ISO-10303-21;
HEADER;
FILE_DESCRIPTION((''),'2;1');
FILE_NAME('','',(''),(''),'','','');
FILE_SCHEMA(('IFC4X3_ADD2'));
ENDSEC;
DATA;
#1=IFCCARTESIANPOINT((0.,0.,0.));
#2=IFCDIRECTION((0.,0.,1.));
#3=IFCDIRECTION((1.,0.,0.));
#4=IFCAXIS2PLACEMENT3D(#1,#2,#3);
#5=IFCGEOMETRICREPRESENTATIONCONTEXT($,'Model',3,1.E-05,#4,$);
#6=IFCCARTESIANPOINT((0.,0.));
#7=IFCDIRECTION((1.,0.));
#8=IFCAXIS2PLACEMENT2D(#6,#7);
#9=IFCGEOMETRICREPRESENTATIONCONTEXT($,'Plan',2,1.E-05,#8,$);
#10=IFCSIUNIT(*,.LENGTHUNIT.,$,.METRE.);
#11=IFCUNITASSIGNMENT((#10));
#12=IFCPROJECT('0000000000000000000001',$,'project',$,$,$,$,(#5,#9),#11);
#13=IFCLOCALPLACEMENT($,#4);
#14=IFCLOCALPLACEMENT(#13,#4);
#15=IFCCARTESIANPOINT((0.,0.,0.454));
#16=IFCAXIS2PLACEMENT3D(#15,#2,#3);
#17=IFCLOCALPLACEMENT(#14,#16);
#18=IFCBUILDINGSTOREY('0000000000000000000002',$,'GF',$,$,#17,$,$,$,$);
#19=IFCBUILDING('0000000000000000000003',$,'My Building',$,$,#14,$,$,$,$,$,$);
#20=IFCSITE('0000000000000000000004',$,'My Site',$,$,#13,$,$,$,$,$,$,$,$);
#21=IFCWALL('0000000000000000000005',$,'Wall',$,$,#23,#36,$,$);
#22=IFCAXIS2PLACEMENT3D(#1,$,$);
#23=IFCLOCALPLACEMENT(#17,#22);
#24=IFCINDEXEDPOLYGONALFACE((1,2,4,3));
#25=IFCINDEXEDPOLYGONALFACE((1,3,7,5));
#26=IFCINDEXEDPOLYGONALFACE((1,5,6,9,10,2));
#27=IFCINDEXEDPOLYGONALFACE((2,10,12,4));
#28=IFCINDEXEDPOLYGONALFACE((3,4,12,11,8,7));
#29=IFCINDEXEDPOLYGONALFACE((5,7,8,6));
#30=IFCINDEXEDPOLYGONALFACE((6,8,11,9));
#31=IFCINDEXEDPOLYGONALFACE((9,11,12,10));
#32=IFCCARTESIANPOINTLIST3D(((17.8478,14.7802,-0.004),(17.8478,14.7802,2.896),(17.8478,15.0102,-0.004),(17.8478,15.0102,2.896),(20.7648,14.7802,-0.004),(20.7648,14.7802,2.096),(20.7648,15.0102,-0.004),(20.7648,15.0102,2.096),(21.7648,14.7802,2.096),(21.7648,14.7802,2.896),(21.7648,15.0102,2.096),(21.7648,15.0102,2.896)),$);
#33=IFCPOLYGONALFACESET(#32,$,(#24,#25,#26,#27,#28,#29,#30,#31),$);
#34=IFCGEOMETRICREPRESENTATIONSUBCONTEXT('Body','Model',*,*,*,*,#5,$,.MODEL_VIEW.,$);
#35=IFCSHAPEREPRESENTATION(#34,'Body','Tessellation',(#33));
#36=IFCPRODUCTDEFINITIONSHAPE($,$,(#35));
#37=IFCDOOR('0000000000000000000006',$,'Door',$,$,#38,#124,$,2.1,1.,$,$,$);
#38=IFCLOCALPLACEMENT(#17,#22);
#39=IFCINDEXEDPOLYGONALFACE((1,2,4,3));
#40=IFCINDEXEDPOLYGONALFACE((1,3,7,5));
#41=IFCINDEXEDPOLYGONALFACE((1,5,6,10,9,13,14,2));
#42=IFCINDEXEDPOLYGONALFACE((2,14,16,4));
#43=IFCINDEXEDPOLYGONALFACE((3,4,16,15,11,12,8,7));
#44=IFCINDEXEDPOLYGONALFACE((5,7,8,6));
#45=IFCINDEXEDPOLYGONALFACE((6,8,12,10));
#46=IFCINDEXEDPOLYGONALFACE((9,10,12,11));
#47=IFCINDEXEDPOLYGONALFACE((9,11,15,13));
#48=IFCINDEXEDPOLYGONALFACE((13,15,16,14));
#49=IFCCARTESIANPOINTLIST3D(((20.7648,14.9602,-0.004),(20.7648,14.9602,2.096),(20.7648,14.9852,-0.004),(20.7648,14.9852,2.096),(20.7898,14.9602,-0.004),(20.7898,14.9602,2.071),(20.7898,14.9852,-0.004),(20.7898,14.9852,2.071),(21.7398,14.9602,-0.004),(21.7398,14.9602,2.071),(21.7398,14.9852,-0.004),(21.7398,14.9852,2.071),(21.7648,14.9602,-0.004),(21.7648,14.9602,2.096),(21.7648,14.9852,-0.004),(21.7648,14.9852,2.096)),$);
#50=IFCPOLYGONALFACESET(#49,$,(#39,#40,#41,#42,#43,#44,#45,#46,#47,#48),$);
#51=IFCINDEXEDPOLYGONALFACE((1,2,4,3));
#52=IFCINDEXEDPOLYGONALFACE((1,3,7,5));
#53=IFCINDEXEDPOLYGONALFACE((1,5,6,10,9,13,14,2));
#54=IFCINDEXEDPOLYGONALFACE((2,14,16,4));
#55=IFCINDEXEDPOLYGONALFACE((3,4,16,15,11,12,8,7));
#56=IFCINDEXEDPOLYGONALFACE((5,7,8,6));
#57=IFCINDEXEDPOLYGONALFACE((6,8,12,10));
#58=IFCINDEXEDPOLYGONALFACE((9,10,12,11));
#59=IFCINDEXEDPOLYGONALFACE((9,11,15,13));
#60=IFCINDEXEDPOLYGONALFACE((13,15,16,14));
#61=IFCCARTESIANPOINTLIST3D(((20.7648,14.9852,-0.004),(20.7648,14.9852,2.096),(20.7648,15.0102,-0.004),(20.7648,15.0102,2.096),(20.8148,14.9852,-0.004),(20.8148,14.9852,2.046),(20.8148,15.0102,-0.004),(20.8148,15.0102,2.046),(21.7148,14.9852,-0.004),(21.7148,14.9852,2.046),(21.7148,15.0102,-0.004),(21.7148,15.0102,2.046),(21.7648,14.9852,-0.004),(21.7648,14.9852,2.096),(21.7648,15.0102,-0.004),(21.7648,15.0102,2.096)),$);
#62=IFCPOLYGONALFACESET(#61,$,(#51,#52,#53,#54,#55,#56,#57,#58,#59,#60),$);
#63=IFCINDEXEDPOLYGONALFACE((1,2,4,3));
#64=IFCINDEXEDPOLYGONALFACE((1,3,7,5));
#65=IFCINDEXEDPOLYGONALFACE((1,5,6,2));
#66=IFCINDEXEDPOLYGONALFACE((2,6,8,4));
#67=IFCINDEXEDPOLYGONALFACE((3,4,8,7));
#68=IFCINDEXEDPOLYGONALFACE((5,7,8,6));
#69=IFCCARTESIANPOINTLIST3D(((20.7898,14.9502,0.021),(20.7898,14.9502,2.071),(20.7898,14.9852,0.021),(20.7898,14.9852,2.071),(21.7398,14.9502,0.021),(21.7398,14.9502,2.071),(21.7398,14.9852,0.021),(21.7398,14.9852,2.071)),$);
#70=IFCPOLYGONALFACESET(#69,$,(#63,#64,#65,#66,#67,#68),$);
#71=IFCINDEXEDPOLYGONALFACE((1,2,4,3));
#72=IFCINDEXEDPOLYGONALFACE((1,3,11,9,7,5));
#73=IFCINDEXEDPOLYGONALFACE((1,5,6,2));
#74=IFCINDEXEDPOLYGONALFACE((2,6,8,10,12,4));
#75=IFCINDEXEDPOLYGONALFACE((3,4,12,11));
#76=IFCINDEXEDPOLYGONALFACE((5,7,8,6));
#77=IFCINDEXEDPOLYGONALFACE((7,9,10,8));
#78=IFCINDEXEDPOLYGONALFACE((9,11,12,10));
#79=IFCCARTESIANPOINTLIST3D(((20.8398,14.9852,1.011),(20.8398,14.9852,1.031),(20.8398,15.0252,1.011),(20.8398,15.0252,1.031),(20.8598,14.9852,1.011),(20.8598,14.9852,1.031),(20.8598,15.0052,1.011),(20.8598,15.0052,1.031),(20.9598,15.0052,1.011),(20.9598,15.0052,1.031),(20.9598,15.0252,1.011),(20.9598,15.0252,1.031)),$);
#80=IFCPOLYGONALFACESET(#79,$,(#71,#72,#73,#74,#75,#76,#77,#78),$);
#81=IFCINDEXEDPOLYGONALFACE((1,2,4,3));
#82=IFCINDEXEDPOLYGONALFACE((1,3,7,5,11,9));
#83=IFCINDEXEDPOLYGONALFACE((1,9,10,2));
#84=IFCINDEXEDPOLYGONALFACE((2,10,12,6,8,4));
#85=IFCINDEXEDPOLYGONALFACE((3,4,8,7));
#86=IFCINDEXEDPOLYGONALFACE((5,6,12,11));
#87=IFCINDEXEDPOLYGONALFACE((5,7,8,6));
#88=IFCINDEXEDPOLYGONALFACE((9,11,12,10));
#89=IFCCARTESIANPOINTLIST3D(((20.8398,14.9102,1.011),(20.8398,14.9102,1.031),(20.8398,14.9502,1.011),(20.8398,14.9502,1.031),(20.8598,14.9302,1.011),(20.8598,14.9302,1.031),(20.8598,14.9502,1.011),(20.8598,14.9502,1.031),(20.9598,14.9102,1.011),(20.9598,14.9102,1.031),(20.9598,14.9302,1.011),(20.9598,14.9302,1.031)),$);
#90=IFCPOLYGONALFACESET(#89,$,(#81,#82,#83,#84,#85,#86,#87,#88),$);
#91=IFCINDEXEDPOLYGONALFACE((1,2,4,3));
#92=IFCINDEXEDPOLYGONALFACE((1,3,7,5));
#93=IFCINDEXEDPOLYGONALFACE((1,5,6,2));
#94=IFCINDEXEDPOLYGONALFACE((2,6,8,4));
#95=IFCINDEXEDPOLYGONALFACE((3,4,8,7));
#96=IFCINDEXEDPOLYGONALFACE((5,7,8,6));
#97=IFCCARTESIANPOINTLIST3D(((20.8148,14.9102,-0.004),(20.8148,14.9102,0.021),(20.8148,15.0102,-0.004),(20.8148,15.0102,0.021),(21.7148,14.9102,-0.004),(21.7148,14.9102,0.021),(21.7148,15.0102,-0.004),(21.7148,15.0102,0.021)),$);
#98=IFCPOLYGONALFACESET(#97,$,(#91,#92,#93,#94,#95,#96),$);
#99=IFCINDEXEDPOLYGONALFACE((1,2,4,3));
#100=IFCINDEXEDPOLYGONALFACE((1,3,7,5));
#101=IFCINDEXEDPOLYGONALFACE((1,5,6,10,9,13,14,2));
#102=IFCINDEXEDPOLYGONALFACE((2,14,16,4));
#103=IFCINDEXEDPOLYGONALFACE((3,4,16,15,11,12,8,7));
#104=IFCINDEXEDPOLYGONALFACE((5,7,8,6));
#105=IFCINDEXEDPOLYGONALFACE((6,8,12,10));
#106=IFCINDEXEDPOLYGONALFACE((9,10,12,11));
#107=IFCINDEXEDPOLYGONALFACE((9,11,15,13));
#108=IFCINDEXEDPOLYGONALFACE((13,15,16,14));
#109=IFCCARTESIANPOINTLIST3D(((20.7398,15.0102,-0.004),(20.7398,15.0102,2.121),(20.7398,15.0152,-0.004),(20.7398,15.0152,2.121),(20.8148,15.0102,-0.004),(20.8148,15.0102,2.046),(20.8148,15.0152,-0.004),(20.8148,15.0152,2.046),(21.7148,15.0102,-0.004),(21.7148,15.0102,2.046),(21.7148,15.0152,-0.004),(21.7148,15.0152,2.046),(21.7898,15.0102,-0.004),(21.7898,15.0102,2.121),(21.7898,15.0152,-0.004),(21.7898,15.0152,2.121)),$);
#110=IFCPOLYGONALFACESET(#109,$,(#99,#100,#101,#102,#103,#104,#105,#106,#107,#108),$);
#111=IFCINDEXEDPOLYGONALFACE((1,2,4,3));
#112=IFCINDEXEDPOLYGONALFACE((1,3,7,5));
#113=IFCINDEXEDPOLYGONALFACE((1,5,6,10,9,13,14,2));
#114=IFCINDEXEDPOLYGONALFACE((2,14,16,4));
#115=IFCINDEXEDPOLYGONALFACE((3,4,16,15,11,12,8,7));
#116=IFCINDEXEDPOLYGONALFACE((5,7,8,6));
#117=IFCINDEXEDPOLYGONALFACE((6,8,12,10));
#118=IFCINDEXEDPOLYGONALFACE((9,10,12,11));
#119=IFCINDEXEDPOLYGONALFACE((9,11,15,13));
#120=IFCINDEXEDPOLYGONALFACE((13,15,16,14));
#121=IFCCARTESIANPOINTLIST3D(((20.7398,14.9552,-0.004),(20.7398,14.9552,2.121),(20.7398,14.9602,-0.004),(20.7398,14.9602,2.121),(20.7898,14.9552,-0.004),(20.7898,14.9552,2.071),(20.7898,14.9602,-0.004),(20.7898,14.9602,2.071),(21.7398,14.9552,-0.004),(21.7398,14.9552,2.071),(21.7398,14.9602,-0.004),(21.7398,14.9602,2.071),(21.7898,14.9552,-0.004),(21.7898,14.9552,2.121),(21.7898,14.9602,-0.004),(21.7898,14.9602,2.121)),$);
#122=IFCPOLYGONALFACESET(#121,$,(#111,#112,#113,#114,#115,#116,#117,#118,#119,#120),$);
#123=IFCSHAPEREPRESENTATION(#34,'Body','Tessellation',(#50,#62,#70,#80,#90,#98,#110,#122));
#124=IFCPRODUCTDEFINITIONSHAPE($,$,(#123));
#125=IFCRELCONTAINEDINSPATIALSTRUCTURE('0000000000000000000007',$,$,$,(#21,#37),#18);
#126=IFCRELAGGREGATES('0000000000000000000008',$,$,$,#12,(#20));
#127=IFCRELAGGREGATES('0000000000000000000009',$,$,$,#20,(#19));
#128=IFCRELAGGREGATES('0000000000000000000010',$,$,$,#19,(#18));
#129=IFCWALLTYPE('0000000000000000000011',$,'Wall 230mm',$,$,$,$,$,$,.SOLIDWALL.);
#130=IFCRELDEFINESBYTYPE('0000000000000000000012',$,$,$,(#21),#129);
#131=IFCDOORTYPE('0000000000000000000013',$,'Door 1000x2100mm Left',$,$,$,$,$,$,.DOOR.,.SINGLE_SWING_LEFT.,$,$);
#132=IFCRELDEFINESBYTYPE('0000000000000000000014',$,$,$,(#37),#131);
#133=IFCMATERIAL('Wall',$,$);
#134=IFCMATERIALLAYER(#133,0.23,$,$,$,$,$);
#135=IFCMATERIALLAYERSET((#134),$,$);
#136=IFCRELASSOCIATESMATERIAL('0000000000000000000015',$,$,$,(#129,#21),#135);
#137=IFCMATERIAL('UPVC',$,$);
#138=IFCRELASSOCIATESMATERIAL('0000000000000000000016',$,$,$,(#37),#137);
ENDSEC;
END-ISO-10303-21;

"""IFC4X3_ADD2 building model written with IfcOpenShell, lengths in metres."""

from ifc_helpers import new_model, entity, si_unit, frame, origin_with_axes, origin_2d_with_axis, place, context, subcontext, project, spatial, line, indexed_curve, outline, extrude, shape, source, transform, mapped, material, layer, layer_set, layer_usage, type_object, type_shapes, element, fill, save


model = new_model("IFC4X3_ADD2")

# Units and contexts
model_context = context("Model", 3, precision=1e-05, world=origin_with_axes())
plan_context = context("Plan", 2, precision=1e-05, world=origin_2d_with_axis())
body_context_1 = subcontext(model_context, "Body", "Model", "MODEL_VIEW")
body_context_2 = subcontext(plan_context, "Body", "Plan", "PLAN_VIEW")
ifc_project = project(units=[si_unit("LENGTHUNIT", "METRE")], contexts=[model_context, plan_context])

# Site, building, storey
site_placement = place(None, origin_with_axes())
site = spatial("IfcSite", under=ifc_project, at=site_placement, Name="My Site")
building_placement = place(site_placement, origin_with_axes())
building = spatial("IfcBuilding", under=site, at=building_placement, Name="My Building")
storey_placement = place(building_placement, frame((0.0, 0.0, 0.454), z_axis=(0.0, 0.0, 1.0), x_axis=(1.0, 0.0, 0.0)))
storey = spatial("IfcBuildingStorey", under=building, at=storey_placement, Name="GF")

# Shared definitions
ifc_material_1 = material(Name="UPVC")

# Shared definitions
ifc_material_2 = material(Name="Wall")

# Shared definitions
shared_shape_1 = source(origin_with_axes(), body_context_1, "Body", "SweptSolid", [
    extrude(outline(indexed_curve([(0.0, 0.0), (1.0, 0.0), (1.0, 2.1), (0.0, 2.1)], segments=[line(1, 2, 3, 4, 1)])), frame((0.0, -0.6, 0.0), z_axis=(0.0, -1.0, 0.0), x_axis=(1.0, 0.0, 0.0)), (0.0, 0.0, -1.0), 1.2),
])
door_type_1 = type_object("IfcDoorType", Name="Door 1000x2100mm Left", OperationType="SINGLE_SWING_LEFT", PredefinedType="DOOR")
shared_shape_2 = source(origin_with_axes(), body_context_1, "Body", "SweptSolid", [
    extrude(outline(indexed_curve([(0.0, 0.0), (0.0, 2.1), (1.0, 2.1), (1.0, 0.0), (0.975, 0.0), (0.975, 2.075), (0.025, 2.075), (0.025, 0.0)], segments=[line(1, 2, 3, 4, 5, 6, 7, 8, 1)])), frame((0.0, 0.025, 0.0), z_axis=(0.0, -1.0, 0.0), x_axis=(1.0, 0.0, 0.0)), (0.0, 0.0, -1.0), 0.025),
    extrude(outline(indexed_curve([(0.0, 0.0), (0.0, 2.1), (1.0, 2.1), (1.0, 0.0), (0.95, 0.0), (0.95, 2.05), (0.05, 2.05), (0.05, 0.0)], segments=[line(1, 2, 3, 4, 5, 6, 7, 8, 1)])), frame((0.0, 0.0, 0.0), z_axis=(0.0, -1.0, 0.0), x_axis=(1.0, 0.0, 0.0)), (0.0, 0.0, -1.0), 0.025),
    extrude(outline(indexed_curve([(0.0, 0.0), (0.95, 0.0), (0.95, 0.035), (0.0, 0.035)], segments=[line(1, 2, 3, 4, 1)])), frame((0.025, 0.025, 0.025), z_axis=(0.0, 0.0, 1.0), x_axis=(1.0, 0.0, 0.0)), (0.0, 0.0, 1.0), 2.05),
    extrude(outline(indexed_curve([(0.0, 0.0), (0.0, -0.04), (-0.12, -0.04), (-0.12, -0.02), (-0.02, -0.02), (-0.02, 0.0)], segments=[line(1, 2, 3, 4, 5, 6, 1)])), frame((0.925, 0.025, 1.015), z_axis=(0.0, 0.0, 1.0), x_axis=(1.0, 0.0, 0.0)), (0.0, 0.0, 1.0), 0.02),
    extrude(outline(indexed_curve([(0.0, 0.0), (0.0, 0.04), (-0.12, 0.04), (-0.12, 0.02), (-0.02, 0.02), (-0.02, 0.0)], segments=[line(1, 2, 3, 4, 5, 6, 1)])), frame((0.925, 0.06, 1.015), z_axis=(0.0, 0.0, 1.0), x_axis=(1.0, 0.0, 0.0)), (0.0, 0.0, 1.0), 0.02),
    extrude(outline(indexed_curve([(0.0, 0.0), (0.9, 0.0), (0.9, 0.1), (0.0, 0.1)], segments=[line(1, 2, 3, 4, 1)])), frame((0.05, 0.0, 0.0), z_axis=(0.0, 0.0, 1.0), x_axis=(1.0, 0.0, 0.0)), (0.0, 0.0, 1.0), 0.025),
    extrude(outline(indexed_curve([(0.0, 0.0), (0.0, 2.125), (1.05, 2.125), (1.05, 0.0), (0.975, 0.0), (0.975, 2.05), (0.075, 2.05), (0.075, 0.0)], segments=[line(1, 2, 3, 4, 5, 6, 7, 8, 1)])), frame((-0.025, -0.005, 0.0), z_axis=(0.0, -1.0, 0.0), x_axis=(1.0, 0.0, 0.0)), (0.0, 0.0, -1.0), 0.005),
    extrude(outline(indexed_curve([(0.0, 0.0), (0.0, 2.125), (1.05, 2.125), (1.05, 0.0), (1.0, 0.0), (1.0, 2.075), (0.05, 2.075), (0.05, 0.0)], segments=[line(1, 2, 3, 4, 5, 6, 7, 8, 1)])), frame((-0.025, 0.05, 0.0), z_axis=(0.0, -1.0, 0.0), x_axis=(1.0, 0.0, 0.0)), (0.0, 0.0, -1.0), 0.005),
])
shared_shape_3 = source(origin_with_axes(), body_context_2, "Body", "Curve2D", [
    entity("IfcIndexedPolyCurve", entity("IfcCartesianPointList2D", [[0.0, 0.0], [0.0, 0.05], [0.025, 0.05], [0.025, 0.025], [0.05, 0.025], [0.05, 0.0]]), [entity("IfcLineIndex", [1, 2, 3, 4, 5, 6, 1])]),
    entity("IfcIndexedPolyCurve", entity("IfcCartesianPointList2D", [[1.0, 0.0], [1.0, 0.05], [0.975, 0.05], [0.975, 0.025], [0.95, 0.025], [0.95, 0.0]]), [entity("IfcLineIndex", [1, 2, 3, 4, 5, 6, 1])]),
    entity("IfcTrimmedCurve", entity("IfcEllipse", entity("IfcAxis2Placement2D", entity("IfcCartesianPoint", [0.06, 0.05]), entity("IfcDirection", [1.0, 0.0])), 0.915, 0.95), [entity("IfcCartesianPoint", [0.975, 0.05])], [entity("IfcCartesianPoint", [0.06, 1.0])], True, "CARTESIAN"),
    entity("IfcIndexedPolyCurve", entity("IfcCartesianPointList2D", [[0.025, 0.05], [0.06, 0.05], [0.06, 1.0], [0.025, 1.0]]), [entity("IfcLineIndex", [1, 2, 3, 4, 1])]),
])
type_shapes(door_type_1, [shared_shape_2, shared_shape_3])

# Shared definitions
ifc_layer_1 = layer(ifc_material_2, 0.23)
ifc_layer_set_1 = layer_set([ifc_layer_1])
wall_type_1 = type_object("IfcWallType", Name="Wall 230mm", PredefinedType="SOLIDWALL", material=ifc_layer_set_1)

# Wall, opening, door
ifc_layer_usage_1 = layer_usage(ifc_layer_set_1, "AXIS2", "POSITIVE", 0.0)
wall_1_placement = place(storey_placement, frame((21.7648, 15.0102, -0.004), z_axis=(0.0, 0.0, 1.0), x_axis=(-1.0, 0.0, 0.0)))
wall_1 = element("IfcWall", 1, at=wall_1_placement, inside=storey, type_object=wall_type_1, material=ifc_layer_usage_1, Name="Wall", context=body_context_1, shape_type="SweptSolid", body=[
    extrude(outline(indexed_curve([(0.0, 0.0), (0.0, 0.23), (3.917, 0.23), (3.917, 0.0), (0.0, 0.0)], self_intersect=False)), origin_with_axes(), (0.0, 0.0, 1.0), 2.9),
])
opening_1_placement = place(wall_1_placement, frame((0.0, 0.0, 0.0), z_axis=(0.0, 0.0, 1.0), x_axis=(1.0, 0.0, 0.0)))
opening_1 = element("IfcOpeningElement", 2, at=opening_1_placement, cuts=wall_1, PredefinedType="OPENING", context=body_context_1, shape_type="MappedRepresentation", body=[
    mapped(shared_shape_1, transform((0.0, 0.0, 0.0), x_axis=(1.0, 0.0, 0.0), y_axis=(0.0, 1.0, 0.0), z_axis=(0.0, 0.0, 1.0), scale=1.0)),
])
door_1_placement = place(opening_1_placement, frame((0.0, 0.0, 0.0), z_axis=(0.0, 0.0, 1.0), x_axis=(1.0, 0.0, 0.0)))
door_1 = element("IfcDoor", 3, at=door_1_placement, inside=storey, type_object=door_type_1, material=ifc_material_1, Name="Door", OverallHeight=2.1, OverallWidth=1.0, shapes=[
    shape(body_context_1, "Body", "MappedRepresentation", [mapped(shared_shape_2, transform((0.0, 0.0, 0.0), x_axis=(1.0, 0.0, 0.0), y_axis=(0.0, 1.0, 0.0), z_axis=(0.0, 0.0, 1.0), scale=1.0))]),
    shape(body_context_2, "Body", "MappedRepresentation", [mapped(shared_shape_3, transform((0.0, 0.0, 0.0), x_axis=(1.0, 0.0, 0.0), y_axis=(0.0, 1.0, 0.0), z_axis=(0.0, 0.0, 1.0), scale=1.0))]),
])
fill(opening_1, door_1)

save(model, "model.ifc")
